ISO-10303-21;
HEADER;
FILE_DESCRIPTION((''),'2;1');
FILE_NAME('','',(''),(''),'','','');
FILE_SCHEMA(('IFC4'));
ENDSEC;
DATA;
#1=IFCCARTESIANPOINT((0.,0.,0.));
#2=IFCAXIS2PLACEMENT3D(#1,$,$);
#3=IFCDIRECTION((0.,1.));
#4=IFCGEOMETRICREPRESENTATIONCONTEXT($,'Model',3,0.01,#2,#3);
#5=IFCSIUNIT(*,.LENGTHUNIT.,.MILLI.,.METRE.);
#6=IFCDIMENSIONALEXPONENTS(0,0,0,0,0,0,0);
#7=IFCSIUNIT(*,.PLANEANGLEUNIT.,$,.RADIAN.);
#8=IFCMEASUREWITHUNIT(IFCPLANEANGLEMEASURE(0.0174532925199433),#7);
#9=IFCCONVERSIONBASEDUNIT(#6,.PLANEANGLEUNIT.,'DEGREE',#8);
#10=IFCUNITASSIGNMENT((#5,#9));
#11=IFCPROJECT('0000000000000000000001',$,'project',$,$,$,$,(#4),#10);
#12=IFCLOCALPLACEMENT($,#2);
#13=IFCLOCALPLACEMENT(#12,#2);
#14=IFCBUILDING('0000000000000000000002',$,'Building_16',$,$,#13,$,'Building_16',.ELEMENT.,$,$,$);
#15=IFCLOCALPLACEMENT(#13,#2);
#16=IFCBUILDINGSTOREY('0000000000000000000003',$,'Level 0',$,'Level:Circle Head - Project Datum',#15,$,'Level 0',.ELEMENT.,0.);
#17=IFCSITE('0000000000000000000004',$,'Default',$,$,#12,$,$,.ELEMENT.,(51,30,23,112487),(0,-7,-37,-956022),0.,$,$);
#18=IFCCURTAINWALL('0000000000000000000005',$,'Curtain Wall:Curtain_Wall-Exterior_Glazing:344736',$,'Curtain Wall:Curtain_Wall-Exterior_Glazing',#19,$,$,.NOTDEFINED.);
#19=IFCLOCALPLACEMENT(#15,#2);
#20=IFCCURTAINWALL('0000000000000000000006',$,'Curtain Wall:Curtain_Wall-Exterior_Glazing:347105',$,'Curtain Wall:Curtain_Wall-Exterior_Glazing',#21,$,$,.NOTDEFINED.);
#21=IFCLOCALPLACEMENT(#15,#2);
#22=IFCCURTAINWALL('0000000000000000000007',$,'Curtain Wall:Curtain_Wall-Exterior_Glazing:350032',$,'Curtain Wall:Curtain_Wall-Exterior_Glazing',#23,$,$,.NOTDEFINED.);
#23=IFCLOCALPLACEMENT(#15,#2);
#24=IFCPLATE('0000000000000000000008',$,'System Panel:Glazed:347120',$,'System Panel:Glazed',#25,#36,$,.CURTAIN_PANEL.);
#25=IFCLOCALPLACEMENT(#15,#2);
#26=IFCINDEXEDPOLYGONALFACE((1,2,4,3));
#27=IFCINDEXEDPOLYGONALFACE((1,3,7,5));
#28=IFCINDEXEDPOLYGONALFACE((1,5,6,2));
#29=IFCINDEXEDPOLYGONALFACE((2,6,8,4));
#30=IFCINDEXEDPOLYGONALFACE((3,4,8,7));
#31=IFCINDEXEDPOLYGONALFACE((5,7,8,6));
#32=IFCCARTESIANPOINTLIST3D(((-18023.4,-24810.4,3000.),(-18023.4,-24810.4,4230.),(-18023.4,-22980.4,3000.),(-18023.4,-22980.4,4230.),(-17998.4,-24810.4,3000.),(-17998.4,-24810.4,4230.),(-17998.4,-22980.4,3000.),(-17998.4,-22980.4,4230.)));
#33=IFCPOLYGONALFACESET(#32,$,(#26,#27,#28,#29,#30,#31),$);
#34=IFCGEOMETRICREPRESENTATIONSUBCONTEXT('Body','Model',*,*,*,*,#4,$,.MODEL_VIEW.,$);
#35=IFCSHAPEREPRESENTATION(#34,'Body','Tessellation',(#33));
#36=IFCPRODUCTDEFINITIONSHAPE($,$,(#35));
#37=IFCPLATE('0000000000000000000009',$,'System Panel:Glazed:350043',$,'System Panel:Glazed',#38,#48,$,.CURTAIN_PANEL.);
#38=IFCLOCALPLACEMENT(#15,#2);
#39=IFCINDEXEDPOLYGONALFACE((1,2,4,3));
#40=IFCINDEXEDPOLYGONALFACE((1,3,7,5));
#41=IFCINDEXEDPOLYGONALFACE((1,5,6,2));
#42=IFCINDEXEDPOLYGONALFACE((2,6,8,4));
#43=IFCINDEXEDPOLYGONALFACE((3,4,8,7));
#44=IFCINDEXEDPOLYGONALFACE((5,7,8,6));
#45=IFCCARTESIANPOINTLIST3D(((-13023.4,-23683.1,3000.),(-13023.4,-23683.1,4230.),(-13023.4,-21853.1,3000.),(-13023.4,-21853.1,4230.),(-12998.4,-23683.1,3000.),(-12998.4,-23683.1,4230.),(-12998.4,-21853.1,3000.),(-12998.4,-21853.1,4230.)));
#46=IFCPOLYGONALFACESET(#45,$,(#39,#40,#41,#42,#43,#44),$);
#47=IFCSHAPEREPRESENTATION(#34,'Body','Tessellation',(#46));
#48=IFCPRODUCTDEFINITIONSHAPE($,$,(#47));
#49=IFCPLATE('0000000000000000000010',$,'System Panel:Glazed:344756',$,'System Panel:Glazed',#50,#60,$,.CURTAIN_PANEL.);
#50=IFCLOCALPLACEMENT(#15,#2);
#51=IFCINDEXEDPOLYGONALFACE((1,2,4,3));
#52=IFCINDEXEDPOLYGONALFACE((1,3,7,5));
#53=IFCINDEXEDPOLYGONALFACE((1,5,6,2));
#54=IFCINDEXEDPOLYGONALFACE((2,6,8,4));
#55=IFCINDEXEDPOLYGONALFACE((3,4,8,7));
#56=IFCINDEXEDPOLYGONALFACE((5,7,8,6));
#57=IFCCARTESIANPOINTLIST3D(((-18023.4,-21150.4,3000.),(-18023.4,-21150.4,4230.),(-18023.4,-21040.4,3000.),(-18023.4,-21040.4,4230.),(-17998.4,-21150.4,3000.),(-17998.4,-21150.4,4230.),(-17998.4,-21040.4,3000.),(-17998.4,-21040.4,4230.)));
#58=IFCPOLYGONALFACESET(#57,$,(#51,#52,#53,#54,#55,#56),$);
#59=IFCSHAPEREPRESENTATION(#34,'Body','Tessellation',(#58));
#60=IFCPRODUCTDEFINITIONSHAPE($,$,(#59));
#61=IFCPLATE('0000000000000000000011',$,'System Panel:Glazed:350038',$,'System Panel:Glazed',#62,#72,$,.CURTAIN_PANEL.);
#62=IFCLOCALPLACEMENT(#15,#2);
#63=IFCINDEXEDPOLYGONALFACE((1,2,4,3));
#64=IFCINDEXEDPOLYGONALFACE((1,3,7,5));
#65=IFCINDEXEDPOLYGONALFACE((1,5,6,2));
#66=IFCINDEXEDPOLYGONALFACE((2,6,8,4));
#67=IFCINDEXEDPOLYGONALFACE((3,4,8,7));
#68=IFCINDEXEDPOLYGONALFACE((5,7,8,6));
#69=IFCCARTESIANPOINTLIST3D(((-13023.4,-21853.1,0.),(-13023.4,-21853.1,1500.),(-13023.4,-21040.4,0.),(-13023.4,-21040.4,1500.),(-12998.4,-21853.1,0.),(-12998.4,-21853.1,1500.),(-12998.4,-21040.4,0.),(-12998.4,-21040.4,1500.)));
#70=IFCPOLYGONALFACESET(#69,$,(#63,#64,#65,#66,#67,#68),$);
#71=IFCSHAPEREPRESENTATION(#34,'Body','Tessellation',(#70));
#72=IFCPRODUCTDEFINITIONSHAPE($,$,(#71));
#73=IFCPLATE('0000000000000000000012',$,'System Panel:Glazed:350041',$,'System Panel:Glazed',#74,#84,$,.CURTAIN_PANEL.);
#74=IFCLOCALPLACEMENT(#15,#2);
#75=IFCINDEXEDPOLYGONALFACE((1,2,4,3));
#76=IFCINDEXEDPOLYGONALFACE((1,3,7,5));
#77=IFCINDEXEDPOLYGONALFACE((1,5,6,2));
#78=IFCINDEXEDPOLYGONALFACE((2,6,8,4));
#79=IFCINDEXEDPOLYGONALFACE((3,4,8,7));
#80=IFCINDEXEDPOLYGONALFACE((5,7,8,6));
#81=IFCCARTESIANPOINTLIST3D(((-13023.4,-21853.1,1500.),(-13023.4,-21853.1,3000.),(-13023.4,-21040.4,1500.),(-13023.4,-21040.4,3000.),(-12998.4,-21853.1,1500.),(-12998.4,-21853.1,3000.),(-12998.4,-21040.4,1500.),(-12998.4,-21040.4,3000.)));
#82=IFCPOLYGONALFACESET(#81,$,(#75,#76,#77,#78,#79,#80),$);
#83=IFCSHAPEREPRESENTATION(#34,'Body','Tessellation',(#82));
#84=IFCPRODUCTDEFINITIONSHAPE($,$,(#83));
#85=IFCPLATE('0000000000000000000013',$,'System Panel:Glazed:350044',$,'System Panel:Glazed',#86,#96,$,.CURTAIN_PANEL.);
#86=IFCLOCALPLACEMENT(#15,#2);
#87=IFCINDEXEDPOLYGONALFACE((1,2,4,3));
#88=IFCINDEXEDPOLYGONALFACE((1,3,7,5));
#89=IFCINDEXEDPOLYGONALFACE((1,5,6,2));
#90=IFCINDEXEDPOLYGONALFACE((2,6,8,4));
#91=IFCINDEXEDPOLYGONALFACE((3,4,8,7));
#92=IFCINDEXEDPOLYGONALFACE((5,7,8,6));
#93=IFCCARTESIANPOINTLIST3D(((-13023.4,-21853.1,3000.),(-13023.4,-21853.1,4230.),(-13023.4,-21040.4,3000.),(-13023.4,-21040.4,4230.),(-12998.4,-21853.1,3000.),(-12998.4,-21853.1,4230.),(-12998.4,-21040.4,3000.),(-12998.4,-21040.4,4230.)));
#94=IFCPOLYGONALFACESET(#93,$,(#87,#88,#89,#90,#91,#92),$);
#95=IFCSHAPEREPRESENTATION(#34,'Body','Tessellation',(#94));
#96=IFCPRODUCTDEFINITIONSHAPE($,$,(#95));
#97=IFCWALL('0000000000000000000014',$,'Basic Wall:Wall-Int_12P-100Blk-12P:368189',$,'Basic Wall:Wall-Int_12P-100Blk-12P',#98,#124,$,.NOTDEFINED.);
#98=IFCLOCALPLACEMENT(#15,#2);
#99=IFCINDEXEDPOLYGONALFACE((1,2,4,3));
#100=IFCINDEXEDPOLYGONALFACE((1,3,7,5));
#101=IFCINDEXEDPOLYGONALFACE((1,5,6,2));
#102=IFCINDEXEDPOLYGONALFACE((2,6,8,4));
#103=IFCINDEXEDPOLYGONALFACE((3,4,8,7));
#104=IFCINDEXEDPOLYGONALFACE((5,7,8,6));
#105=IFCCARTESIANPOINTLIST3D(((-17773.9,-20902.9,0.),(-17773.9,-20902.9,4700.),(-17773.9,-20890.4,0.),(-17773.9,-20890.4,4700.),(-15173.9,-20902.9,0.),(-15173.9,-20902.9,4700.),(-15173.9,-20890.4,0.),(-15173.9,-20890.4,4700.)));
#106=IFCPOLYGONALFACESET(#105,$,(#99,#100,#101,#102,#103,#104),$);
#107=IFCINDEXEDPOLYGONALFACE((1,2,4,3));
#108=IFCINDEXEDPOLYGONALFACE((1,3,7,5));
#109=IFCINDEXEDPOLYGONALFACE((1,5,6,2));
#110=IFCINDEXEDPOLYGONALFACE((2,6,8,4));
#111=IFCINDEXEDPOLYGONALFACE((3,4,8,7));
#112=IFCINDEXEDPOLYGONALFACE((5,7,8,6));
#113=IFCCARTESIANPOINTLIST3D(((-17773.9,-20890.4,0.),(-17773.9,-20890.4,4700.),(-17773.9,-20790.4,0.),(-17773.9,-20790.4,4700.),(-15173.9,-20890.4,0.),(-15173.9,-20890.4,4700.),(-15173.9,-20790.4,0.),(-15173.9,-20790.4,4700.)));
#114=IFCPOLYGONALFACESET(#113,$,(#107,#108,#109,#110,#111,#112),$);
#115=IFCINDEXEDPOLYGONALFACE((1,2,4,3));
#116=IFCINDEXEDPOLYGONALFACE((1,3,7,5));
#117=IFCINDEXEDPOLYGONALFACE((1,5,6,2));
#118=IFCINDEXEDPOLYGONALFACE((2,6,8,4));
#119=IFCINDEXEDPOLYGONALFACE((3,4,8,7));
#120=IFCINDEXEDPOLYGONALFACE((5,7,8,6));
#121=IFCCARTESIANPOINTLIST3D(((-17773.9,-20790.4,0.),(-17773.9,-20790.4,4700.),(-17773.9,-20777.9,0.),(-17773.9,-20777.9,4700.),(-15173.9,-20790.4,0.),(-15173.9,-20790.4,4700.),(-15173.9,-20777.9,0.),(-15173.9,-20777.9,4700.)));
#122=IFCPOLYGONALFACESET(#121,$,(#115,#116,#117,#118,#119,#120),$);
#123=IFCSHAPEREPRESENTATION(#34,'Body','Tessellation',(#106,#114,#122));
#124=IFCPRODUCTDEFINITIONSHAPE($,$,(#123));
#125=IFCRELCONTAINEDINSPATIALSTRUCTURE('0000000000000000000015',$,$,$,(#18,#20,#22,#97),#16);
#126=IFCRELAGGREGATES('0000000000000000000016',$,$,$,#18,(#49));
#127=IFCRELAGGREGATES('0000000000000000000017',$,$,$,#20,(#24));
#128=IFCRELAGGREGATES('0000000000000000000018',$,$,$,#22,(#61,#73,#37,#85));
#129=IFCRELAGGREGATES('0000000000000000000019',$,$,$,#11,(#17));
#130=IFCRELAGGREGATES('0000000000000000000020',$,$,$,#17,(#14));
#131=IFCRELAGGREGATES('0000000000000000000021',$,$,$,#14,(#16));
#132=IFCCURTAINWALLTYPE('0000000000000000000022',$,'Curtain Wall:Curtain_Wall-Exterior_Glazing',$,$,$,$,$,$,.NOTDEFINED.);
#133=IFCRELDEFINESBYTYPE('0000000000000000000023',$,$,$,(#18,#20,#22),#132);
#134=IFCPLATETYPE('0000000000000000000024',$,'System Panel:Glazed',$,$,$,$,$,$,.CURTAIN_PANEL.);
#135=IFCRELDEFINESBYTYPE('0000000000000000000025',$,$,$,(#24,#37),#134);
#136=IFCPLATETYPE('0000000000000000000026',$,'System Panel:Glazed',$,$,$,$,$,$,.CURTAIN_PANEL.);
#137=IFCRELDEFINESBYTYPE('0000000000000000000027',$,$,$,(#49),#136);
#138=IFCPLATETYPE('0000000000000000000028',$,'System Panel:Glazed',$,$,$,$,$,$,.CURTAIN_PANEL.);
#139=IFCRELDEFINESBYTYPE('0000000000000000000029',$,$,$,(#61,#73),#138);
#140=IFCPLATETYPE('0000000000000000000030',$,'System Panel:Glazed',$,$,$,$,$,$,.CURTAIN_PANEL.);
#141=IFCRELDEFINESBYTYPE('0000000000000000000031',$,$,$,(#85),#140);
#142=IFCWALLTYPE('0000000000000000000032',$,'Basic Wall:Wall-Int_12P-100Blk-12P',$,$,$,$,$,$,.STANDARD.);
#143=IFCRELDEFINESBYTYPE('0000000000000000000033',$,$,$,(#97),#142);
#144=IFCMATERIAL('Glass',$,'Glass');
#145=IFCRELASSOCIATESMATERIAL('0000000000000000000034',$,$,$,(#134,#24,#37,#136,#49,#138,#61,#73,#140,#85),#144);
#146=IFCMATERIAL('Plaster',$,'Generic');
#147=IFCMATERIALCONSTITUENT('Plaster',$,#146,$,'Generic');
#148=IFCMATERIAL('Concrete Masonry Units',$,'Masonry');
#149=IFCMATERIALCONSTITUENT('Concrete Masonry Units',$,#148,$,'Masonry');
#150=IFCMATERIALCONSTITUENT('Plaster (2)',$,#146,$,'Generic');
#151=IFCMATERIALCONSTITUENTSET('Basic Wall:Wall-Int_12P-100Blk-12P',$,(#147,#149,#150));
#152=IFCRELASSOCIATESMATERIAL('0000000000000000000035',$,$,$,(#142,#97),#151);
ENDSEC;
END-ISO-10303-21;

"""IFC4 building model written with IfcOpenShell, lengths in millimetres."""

from ifc_helpers import new_model, entity, si_unit, converted_unit, direction, frame, origin, place, context, subcontext, project, spatial, indexed_curve, outline, extrude, source, transform, mapped, material, constituent, constituent_set, type_object, type_shapes, element, aggregate, save


model = new_model("IFC4")

# Units and contexts
model_context = context("Model", 3, precision=0.01, world=origin(), true_north=direction((0.0, 1.0)))
body_context = subcontext(model_context, "Body", "Model", "MODEL_VIEW")
ifc_project = project(units=[si_unit("LENGTHUNIT", "METRE", prefix="MILLI"), converted_unit("PLANEANGLEUNIT", "DEGREE", entity("IfcPlaneAngleMeasure", 0.0174532925199433), si_unit("PLANEANGLEUNIT", "RADIAN"), dimensions=[0, 0, 0, 0, 0, 0, 0])], contexts=[model_context])

# Site, building, storey
site_placement = place(None, origin())
site = spatial("IfcSite", under=ifc_project, at=site_placement, Name="Default", CompositionType="ELEMENT", RefLatitude=(51, 30, 23, 112487), RefLongitude=(0, -7, -37, -956022), RefElevation=0.0)
building_placement = place(site_placement, origin())
building = spatial("IfcBuilding", under=site, at=building_placement, Name="Building_16", LongName="Building_16", CompositionType="ELEMENT")
storey_placement = place(building_placement, origin())
storey = spatial("IfcBuildingStorey", under=building, at=storey_placement, Name="Level 0", ObjectType="Level:Circle Head - Project Datum", LongName="Level 0", CompositionType="ELEMENT", Elevation=0.0)

# Curtain walls
curtain_wall_type = type_object("IfcCurtainWallType", Name="Curtain Wall:Curtain_Wall-Exterior_Glazing", PredefinedType="NOTDEFINED")
curtain_wall_1_placement = place(storey_placement, origin())
curtain_wall_1 = element("IfcCurtainWall", 1, at=curtain_wall_1_placement, inside=storey, type_object=curtain_wall_type, Name="Curtain Wall:Curtain_Wall-Exterior_Glazing:344736", ObjectType="Curtain Wall:Curtain_Wall-Exterior_Glazing", PredefinedType="NOTDEFINED")
ifc_material_1 = material(Name="Glass", Category="Glass")
curtain_wall_2_placement = place(storey_placement, origin())
curtain_wall_2 = element("IfcCurtainWall", 2, at=curtain_wall_2_placement, inside=storey, type_object=curtain_wall_type, Name="Curtain Wall:Curtain_Wall-Exterior_Glazing:347105", ObjectType="Curtain Wall:Curtain_Wall-Exterior_Glazing", PredefinedType="NOTDEFINED")

# Curtain wall
curtain_wall_3_placement = place(storey_placement, origin())
curtain_wall_3 = element("IfcCurtainWall", 3, at=curtain_wall_3_placement, inside=storey, type_object=curtain_wall_type, Name="Curtain Wall:Curtain_Wall-Exterior_Glazing:350032", ObjectType="Curtain Wall:Curtain_Wall-Exterior_Glazing", PredefinedType="NOTDEFINED")

# Plates
plate_type_1 = type_object("IfcPlateType", Name="System Panel:Glazed", PredefinedType="CURTAIN_PANEL", material=ifc_material_1)
shared_shape_1 = source(origin(), body_context, "Body", "SweptSolid", [
    extrude(outline(indexed_curve([(-12.5, -915.0), (12.5, -915.0), (12.5, 915.0), (-12.5, 915.0), (-12.5, -915.0)], self_intersect=False)), frame((0.0, 37.0, 0.0), z_axis=(0.0, 0.0, 1.0), x_axis=(0.0, 1.0, 0.0)), (0.0, 0.0, 1.0), 1230.0),
])
type_shapes(plate_type_1, [shared_shape_1])
plate_1_placement = place(curtain_wall_2_placement, frame((-17973.9, -23895.4, 3000.0), z_axis=(0.0, 0.0, 1.0), x_axis=(0.0, 1.0, 0.0)))
plate_1 = element("IfcPlate", 4, at=plate_1_placement, type_object=plate_type_1, material=ifc_material_1, Name="System Panel:Glazed:347120", ObjectType="System Panel:Glazed", PredefinedType="CURTAIN_PANEL", context=body_context, shape_type="MappedRepresentation", body=[
    mapped(shared_shape_1, transform((0.0, 0.0, 0.0), scale=1.0)),
])
plate_2_placement = place(curtain_wall_3_placement, frame((-12973.9, -22768.1, 3000.0), z_axis=(0.0, 0.0, 1.0), x_axis=(0.0, 1.0, 0.0)))
plate_2 = element("IfcPlate", 5, at=plate_2_placement, type_object=plate_type_1, material=ifc_material_1, Name="System Panel:Glazed:350043", ObjectType="System Panel:Glazed", PredefinedType="CURTAIN_PANEL", context=body_context, shape_type="MappedRepresentation", body=[
    mapped(shared_shape_1, transform((0.0, 0.0, 0.0), scale=1.0)),
])
plate_type_2 = type_object("IfcPlateType", Name="System Panel:Glazed", PredefinedType="CURTAIN_PANEL", material=ifc_material_1)
shared_shape_2 = source(origin(), body_context, "Body", "SweptSolid", [
    extrude(outline(indexed_curve([(-12.5, -55.0), (12.5, -55.0), (12.5, 55.0), (-12.5, 55.0), (-12.5, -55.0)], self_intersect=False)), frame((0.0, 37.0, 0.0), z_axis=(0.0, 0.0, 1.0), x_axis=(0.0, 1.0, 0.0)), (0.0, 0.0, 1.0), 1230.0),
])
type_shapes(plate_type_2, [shared_shape_2])
plate_3_placement = place(curtain_wall_1_placement, frame((-17973.9, -21095.4, 3000.0), z_axis=(0.0, 0.0, 1.0), x_axis=(0.0, 1.0, 0.0)))
plate_3 = element("IfcPlate", 6, at=plate_3_placement, type_object=plate_type_2, material=ifc_material_1, Name="System Panel:Glazed:344756", ObjectType="System Panel:Glazed", PredefinedType="CURTAIN_PANEL", context=body_context, shape_type="MappedRepresentation", body=[
    mapped(shared_shape_2, transform((0.0, 0.0, 0.0), scale=1.0)),
])
aggregate(curtain_wall_1, [plate_3])
aggregate(curtain_wall_2, [plate_1])
plate_type_3 = type_object("IfcPlateType", Name="System Panel:Glazed", PredefinedType="CURTAIN_PANEL", material=ifc_material_1)
shared_shape_3 = source(origin(), body_context, "Body", "SweptSolid", [
    extrude(outline(indexed_curve([(-12.5, -406.4), (12.5, -406.4), (12.5, 406.4), (-12.5, 406.4), (-12.5, -406.4)], self_intersect=False)), frame((0.0, 37.0, 0.0), z_axis=(0.0, 0.0, 1.0), x_axis=(0.0, 1.0, 0.0)), (0.0, 0.0, 1.0), 1500.0),
])
type_shapes(plate_type_3, [shared_shape_3])
plate_4_placement = place(curtain_wall_3_placement, frame((-12973.9, -21446.7, 0.0), z_axis=(0.0, 0.0, 1.0), x_axis=(0.0, 1.0, 0.0)))
plate_4 = element("IfcPlate", 7, at=plate_4_placement, type_object=plate_type_3, material=ifc_material_1, Name="System Panel:Glazed:350038", ObjectType="System Panel:Glazed", PredefinedType="CURTAIN_PANEL", context=body_context, shape_type="MappedRepresentation", body=[
    mapped(shared_shape_3, transform((0.0, 0.0, 0.0), scale=1.0)),
])
plate_5_placement = place(curtain_wall_3_placement, frame((-12973.9, -21446.7, 1500.0), z_axis=(0.0, 0.0, 1.0), x_axis=(0.0, 1.0, 0.0)))
plate_5 = element("IfcPlate", 8, at=plate_5_placement, type_object=plate_type_3, material=ifc_material_1, Name="System Panel:Glazed:350041", ObjectType="System Panel:Glazed", PredefinedType="CURTAIN_PANEL", context=body_context, shape_type="MappedRepresentation", body=[
    mapped(shared_shape_3, transform((0.0, 0.0, 0.0), scale=1.0)),
])
plate_type_4 = type_object("IfcPlateType", Name="System Panel:Glazed", PredefinedType="CURTAIN_PANEL", material=ifc_material_1)
shared_shape_4 = source(origin(), body_context, "Body", "SweptSolid", [
    extrude(outline(indexed_curve([(-12.5, -406.4), (12.5, -406.4), (12.5, 406.4), (-12.5, 406.4), (-12.5, -406.4)], self_intersect=False)), frame((0.0, 37.0, 0.0), z_axis=(0.0, 0.0, 1.0), x_axis=(0.0, 1.0, 0.0)), (0.0, 0.0, 1.0), 1230.0),
])
type_shapes(plate_type_4, [shared_shape_4])
plate_6_placement = place(curtain_wall_3_placement, frame((-12973.9, -21446.7, 3000.0), z_axis=(0.0, 0.0, 1.0), x_axis=(0.0, 1.0, 0.0)))
plate_6 = element("IfcPlate", 9, at=plate_6_placement, type_object=plate_type_4, material=ifc_material_1, Name="System Panel:Glazed:350044", ObjectType="System Panel:Glazed", PredefinedType="CURTAIN_PANEL", context=body_context, shape_type="MappedRepresentation", body=[
    mapped(shared_shape_4, transform((0.0, 0.0, 0.0), scale=1.0)),
])
aggregate(curtain_wall_3, [plate_4, plate_5, plate_2, plate_6])

# Shared definitions
ifc_material_2 = material(Name="Concrete Masonry Units", Category="Masonry")
ifc_material_3 = material(Name="Plaster", Category="Generic")

# Wall
ifc_constituent_1 = constituent(ifc_material_3, Name="Plaster", Category="Generic")
ifc_constituent_2 = constituent(ifc_material_2, Name="Concrete Masonry Units", Category="Masonry")
ifc_constituent_3 = constituent(ifc_material_3, Name="Plaster (2)", Category="Generic")
ifc_constituent_set_1 = constituent_set(constituents=[ifc_constituent_1, ifc_constituent_2, ifc_constituent_3], Name="Basic Wall:Wall-Int_12P-100Blk-12P")
wall_type_1 = type_object("IfcWallType", Name="Basic Wall:Wall-Int_12P-100Blk-12P", PredefinedType="STANDARD", material=ifc_constituent_set_1)
wall_1_placement = place(storey_placement, frame((-17773.9, -20840.4, 0.0)))
element("IfcWall", 10, at=wall_1_placement, inside=storey, type_object=wall_type_1, material=ifc_constituent_set_1, Name="Basic Wall:Wall-Int_12P-100Blk-12P:368189", ObjectType="Basic Wall:Wall-Int_12P-100Blk-12P", PredefinedType="NOTDEFINED", context=body_context, shape_type="SweptSolid", body=[
    extrude(outline(indexed_curve([(-6.3, -1300.0), (6.2, -1300.0), (6.3, 1300.0), (-6.2, 1300.0), (-6.3, -1300.0)], self_intersect=False)), frame((1300.0, -56.3, 0.0), z_axis=(0.0, 0.0, 1.0), x_axis=(0.0, 1.0, 0.0)), (0.0, 0.0, 1.0), 4700.0),
    extrude(outline(indexed_curve([(-1300.0, -50.0), (1300.0, -50.0), (1300.0, 50.0), (-1300.0, 50.0), (-1300.0, -50.0)], self_intersect=False)), frame((1300.0, 0.0, 0.0)), (0.0, 0.0, 1.0), 4700.0),
    extrude(outline(indexed_curve([(-6.3, -1300.0), (6.2, -1300.0), (6.3, 1300.0), (-6.2, 1300.0), (-6.3, -1300.0)], self_intersect=False)), frame((1300.0, 56.3, 0.0), z_axis=(0.0, 0.0, 1.0), x_axis=(0.0, -1.0, 0.0)), (0.0, 0.0, 1.0), 4700.0),
])

save(model, "model.ifc")
